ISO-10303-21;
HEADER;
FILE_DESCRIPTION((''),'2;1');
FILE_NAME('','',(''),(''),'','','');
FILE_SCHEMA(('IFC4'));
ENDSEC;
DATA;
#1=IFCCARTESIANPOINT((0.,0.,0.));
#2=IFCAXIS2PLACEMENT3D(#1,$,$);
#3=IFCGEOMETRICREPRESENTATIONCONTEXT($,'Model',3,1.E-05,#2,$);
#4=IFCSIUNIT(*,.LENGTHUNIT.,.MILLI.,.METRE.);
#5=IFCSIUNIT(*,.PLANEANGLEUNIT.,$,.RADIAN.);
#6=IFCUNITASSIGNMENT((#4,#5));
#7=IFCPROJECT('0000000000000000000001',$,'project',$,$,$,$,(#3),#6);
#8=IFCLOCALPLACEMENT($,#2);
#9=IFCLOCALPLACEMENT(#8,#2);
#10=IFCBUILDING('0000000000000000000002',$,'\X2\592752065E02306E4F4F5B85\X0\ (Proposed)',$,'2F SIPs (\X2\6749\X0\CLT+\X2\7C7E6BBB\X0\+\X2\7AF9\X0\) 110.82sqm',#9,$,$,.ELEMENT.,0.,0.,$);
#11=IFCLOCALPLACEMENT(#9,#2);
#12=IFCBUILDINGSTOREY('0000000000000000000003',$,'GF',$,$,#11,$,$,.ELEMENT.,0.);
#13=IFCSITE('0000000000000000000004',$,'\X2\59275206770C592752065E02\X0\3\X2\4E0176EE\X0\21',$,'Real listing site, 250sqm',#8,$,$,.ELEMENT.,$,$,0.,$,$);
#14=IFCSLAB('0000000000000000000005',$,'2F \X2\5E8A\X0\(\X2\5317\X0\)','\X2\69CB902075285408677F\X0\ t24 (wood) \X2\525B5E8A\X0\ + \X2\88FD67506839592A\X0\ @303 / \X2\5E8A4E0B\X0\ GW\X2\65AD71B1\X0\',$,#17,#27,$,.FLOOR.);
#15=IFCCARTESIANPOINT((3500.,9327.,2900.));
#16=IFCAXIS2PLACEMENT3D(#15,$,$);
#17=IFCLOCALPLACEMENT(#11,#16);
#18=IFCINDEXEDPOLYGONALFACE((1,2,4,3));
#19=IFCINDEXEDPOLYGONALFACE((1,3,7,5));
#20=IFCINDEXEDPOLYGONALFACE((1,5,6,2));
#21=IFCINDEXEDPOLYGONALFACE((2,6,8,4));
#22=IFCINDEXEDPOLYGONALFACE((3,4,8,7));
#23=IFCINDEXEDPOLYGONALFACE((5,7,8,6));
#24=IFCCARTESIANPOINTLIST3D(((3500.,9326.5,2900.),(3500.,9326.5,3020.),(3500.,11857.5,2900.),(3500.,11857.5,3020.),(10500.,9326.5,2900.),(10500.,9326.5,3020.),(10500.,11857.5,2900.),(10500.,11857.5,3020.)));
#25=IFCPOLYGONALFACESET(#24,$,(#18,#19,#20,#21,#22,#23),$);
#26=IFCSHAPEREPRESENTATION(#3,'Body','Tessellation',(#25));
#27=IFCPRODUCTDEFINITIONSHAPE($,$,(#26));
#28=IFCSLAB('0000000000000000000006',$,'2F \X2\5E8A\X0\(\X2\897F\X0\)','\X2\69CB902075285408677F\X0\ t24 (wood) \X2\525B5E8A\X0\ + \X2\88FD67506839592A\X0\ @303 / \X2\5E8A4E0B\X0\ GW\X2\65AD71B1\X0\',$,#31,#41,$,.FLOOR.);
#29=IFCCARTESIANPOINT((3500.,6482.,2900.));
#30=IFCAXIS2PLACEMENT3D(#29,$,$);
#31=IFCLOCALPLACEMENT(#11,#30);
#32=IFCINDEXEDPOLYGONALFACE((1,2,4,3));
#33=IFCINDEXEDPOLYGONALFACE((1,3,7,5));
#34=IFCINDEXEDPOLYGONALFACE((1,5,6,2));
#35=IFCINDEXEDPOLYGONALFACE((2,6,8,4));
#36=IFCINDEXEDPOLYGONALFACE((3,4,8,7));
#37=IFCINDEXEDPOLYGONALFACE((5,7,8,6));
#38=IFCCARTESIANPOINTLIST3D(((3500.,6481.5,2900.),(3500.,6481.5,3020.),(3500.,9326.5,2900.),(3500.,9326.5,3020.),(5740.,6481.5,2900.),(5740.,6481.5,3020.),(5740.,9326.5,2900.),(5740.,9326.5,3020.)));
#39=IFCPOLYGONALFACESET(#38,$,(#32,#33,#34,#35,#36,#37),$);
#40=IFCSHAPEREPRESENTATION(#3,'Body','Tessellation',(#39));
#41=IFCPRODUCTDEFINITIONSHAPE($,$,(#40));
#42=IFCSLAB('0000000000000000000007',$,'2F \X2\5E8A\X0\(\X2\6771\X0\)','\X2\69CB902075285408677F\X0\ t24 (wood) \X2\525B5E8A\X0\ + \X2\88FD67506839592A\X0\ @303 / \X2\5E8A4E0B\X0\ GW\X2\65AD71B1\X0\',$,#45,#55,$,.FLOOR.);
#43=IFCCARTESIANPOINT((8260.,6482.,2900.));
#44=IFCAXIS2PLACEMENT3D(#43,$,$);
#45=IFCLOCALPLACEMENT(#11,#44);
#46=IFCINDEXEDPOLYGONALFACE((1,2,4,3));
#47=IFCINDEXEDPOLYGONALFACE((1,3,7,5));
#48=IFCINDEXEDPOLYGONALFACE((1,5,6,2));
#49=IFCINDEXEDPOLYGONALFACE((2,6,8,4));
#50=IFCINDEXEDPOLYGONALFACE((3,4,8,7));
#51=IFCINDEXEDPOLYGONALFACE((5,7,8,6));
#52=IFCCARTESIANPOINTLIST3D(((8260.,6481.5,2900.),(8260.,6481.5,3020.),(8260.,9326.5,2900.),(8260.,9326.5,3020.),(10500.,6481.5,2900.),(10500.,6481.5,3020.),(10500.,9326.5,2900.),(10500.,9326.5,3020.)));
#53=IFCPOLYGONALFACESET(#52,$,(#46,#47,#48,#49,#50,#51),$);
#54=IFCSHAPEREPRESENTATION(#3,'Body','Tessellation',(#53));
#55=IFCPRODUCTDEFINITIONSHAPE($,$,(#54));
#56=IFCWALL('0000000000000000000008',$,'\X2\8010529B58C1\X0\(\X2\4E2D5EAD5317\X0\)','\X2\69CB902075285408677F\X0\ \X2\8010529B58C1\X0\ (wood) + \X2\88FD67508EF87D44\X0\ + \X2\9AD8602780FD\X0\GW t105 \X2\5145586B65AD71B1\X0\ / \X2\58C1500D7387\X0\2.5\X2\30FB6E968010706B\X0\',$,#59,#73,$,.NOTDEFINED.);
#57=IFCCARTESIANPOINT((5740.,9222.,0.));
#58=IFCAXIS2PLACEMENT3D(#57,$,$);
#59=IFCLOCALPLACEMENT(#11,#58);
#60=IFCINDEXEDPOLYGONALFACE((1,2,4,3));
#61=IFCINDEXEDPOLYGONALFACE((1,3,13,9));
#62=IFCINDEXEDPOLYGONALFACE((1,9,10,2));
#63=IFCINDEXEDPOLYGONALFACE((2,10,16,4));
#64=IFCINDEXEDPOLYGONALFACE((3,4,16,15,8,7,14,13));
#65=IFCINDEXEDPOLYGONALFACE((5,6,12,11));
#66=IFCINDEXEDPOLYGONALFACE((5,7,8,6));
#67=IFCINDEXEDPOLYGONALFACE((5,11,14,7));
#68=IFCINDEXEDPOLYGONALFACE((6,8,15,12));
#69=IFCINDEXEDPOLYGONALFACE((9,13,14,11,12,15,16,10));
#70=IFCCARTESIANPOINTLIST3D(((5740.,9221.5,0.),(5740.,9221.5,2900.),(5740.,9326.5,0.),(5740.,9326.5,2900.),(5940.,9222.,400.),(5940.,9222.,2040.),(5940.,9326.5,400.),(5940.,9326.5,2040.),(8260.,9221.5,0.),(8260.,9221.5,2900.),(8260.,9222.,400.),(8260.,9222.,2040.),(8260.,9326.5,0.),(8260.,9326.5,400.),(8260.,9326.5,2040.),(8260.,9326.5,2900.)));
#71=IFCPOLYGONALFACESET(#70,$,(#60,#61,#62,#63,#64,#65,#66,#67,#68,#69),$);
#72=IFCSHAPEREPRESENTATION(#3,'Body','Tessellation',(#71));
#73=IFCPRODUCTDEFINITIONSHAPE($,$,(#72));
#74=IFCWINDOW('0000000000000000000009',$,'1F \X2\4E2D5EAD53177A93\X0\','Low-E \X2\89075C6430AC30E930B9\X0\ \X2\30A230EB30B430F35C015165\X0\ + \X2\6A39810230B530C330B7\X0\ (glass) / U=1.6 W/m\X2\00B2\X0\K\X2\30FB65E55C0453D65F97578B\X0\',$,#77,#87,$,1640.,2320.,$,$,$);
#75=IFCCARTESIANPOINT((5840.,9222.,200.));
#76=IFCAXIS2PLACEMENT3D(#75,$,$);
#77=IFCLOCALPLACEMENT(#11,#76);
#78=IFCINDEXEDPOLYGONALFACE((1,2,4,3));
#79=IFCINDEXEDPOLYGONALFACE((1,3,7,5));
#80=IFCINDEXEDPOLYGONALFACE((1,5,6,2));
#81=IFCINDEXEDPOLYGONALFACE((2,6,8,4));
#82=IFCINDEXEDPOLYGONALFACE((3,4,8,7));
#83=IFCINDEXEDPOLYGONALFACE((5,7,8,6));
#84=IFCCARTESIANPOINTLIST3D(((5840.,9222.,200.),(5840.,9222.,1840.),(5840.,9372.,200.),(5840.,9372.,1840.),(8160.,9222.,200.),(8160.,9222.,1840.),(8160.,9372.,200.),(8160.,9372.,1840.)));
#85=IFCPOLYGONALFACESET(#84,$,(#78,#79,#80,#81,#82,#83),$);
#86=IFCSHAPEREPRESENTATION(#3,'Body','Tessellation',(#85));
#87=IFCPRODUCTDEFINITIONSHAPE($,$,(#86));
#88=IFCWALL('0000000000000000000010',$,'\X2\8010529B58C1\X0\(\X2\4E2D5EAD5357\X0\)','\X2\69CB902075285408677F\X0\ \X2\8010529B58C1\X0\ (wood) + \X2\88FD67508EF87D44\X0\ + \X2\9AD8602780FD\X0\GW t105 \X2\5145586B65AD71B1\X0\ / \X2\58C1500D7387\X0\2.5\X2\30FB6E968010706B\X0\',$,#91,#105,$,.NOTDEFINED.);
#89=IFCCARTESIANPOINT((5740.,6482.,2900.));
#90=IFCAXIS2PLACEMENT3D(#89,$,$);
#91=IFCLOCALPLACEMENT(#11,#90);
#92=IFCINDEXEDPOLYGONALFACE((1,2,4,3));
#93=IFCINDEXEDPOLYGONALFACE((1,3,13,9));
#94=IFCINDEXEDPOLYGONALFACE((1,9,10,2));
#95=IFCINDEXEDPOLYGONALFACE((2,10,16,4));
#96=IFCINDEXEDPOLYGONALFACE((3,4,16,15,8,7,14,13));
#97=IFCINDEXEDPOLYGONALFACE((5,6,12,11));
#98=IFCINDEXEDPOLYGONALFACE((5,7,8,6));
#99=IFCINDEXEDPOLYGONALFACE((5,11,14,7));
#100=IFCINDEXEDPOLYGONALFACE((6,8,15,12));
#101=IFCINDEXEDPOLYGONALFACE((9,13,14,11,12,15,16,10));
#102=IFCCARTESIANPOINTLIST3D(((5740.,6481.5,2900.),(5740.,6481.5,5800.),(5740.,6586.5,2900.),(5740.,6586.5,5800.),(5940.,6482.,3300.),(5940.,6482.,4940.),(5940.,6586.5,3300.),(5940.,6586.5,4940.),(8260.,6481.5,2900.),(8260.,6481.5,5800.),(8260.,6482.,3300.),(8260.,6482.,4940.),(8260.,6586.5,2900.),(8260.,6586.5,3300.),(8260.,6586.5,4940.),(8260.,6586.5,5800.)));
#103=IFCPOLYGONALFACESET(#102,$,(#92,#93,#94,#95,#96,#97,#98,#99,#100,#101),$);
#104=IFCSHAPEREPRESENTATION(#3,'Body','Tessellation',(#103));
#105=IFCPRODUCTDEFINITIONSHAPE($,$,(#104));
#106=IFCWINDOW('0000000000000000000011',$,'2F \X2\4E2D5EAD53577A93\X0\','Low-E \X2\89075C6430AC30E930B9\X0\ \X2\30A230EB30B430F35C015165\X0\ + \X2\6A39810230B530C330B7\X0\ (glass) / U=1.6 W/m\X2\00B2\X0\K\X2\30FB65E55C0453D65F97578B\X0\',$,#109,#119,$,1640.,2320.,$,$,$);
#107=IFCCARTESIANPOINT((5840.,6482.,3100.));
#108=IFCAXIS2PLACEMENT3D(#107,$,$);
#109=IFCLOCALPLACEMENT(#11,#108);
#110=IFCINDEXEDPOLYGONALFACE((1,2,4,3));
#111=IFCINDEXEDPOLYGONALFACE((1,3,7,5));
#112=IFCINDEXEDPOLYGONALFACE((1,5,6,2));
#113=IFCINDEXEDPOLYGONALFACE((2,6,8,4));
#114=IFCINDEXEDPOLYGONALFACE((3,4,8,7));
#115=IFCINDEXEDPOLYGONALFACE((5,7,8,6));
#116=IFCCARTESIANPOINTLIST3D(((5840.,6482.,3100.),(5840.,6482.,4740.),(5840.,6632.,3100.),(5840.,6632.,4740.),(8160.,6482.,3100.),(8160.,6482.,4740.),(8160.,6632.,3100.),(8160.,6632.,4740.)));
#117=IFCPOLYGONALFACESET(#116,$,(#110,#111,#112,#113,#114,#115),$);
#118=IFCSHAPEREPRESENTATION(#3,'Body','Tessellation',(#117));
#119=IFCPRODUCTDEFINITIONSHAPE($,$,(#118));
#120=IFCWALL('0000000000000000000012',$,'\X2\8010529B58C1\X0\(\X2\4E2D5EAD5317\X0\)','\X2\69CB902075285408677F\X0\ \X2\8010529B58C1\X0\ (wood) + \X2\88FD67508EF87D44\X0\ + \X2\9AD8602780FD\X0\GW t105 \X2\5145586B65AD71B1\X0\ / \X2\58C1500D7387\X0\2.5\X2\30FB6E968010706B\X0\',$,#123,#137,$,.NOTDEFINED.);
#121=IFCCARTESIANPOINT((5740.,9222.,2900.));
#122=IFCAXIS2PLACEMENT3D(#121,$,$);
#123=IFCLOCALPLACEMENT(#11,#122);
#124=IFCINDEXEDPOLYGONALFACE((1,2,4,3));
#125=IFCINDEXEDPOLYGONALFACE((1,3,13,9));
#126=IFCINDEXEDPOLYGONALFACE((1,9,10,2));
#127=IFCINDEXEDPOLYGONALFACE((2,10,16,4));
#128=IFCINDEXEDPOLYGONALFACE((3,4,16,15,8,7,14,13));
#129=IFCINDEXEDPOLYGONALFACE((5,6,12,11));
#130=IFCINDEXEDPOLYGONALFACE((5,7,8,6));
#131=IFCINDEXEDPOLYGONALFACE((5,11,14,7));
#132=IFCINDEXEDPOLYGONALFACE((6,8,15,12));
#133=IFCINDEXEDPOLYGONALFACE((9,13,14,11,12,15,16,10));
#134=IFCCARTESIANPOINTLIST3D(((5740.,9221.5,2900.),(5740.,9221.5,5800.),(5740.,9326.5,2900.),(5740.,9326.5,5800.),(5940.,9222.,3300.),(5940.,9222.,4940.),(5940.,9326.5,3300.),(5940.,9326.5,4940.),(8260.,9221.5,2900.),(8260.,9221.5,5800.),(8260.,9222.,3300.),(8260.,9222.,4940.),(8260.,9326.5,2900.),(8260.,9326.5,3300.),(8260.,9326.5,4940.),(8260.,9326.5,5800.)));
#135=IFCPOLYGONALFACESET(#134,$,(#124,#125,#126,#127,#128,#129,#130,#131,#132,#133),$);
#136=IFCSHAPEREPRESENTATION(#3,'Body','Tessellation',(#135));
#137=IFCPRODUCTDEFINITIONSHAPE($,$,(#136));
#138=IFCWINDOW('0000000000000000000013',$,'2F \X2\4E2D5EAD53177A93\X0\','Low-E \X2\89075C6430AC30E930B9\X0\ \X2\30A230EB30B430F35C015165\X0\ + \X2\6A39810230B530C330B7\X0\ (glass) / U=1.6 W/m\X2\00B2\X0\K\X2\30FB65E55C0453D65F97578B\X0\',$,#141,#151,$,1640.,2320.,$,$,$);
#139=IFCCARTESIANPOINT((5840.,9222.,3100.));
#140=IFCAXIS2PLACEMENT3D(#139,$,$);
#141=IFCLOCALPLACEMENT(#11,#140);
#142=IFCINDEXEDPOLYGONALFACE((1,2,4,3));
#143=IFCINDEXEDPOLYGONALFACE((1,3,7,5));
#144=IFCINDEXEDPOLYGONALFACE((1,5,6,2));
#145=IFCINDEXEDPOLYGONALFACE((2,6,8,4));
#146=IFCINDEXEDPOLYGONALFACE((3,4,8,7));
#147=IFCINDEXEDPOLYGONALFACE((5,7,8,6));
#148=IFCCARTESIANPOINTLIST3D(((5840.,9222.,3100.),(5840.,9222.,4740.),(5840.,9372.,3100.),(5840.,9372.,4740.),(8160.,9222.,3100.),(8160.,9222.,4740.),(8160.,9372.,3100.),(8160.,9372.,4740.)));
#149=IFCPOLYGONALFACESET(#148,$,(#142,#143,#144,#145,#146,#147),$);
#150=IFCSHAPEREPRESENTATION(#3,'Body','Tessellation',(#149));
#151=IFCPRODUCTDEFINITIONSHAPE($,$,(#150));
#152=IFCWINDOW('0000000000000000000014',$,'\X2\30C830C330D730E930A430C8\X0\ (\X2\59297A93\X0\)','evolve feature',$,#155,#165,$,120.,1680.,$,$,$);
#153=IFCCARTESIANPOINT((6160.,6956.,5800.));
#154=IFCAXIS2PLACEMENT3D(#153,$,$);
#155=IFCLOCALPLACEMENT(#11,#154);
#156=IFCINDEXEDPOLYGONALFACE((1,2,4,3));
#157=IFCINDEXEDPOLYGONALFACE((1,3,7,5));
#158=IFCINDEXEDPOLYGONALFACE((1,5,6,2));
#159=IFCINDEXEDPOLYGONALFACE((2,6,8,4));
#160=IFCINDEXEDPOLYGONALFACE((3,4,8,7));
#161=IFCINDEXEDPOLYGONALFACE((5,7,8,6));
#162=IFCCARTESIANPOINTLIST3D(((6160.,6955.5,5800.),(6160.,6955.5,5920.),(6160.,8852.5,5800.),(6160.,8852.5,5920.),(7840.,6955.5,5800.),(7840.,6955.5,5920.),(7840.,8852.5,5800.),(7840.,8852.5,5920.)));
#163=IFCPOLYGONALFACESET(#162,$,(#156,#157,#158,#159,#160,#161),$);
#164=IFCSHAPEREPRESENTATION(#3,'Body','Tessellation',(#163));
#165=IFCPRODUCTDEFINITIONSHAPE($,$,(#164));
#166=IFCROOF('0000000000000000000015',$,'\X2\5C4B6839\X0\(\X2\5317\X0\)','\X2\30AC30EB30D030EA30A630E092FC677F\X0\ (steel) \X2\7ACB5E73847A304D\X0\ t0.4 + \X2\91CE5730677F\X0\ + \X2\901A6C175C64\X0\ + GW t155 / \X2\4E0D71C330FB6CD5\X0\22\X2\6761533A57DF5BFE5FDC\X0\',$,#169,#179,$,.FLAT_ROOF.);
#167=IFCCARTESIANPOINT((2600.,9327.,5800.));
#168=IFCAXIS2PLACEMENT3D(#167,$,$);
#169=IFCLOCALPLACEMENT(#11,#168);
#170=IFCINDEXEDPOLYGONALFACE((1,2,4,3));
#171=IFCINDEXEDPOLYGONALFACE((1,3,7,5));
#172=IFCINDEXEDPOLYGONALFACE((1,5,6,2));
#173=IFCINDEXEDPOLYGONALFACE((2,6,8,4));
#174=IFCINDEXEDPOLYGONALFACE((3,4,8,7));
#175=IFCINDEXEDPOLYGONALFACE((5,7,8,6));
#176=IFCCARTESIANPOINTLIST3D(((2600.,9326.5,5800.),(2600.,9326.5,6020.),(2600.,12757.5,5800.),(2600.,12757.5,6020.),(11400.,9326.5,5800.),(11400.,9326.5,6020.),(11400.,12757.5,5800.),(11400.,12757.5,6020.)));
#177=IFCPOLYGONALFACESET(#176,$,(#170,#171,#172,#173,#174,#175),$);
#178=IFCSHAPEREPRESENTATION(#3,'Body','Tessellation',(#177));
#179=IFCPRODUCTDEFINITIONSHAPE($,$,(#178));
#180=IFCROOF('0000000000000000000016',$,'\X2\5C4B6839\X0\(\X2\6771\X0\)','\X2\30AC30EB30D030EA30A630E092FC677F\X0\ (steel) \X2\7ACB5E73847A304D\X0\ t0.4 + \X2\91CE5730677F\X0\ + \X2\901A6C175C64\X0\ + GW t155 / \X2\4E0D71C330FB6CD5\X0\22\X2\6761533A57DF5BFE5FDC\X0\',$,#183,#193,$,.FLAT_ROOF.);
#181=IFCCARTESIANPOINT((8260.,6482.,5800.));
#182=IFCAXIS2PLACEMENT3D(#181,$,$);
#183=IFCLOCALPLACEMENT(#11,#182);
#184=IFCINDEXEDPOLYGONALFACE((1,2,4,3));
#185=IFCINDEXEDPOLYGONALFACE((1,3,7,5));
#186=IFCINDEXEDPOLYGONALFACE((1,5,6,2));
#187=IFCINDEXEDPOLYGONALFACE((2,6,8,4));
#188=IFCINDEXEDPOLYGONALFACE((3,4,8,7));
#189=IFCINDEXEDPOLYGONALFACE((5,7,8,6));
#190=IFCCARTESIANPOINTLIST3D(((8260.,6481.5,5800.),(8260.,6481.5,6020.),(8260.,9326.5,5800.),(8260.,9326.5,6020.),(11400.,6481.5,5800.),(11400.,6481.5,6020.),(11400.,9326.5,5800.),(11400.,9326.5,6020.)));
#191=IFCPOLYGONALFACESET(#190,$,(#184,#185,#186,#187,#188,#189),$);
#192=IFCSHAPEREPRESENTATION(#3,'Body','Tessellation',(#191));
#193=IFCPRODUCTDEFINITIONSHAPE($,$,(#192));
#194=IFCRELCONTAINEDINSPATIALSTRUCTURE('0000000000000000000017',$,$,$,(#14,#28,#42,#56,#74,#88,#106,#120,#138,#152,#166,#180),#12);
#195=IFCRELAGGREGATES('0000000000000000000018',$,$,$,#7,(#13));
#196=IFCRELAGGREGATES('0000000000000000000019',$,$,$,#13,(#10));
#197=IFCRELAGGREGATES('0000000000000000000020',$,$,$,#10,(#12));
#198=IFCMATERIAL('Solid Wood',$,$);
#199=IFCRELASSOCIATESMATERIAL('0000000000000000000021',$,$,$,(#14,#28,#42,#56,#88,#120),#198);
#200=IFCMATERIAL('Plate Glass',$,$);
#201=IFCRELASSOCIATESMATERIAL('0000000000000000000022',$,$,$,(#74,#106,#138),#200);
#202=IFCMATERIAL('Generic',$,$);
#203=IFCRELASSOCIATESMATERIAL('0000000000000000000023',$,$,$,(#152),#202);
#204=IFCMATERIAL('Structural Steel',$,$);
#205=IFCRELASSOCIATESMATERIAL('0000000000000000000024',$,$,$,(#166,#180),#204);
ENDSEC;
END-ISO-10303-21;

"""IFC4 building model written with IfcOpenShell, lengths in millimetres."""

from ifc_helpers import new_model, si_unit, frame, frame_2d, origin, place, context, project, spatial, rectangle, extrude, material, element, fill, save


model = new_model("IFC4")

# Units and contexts
model_context = context("Model", 3, precision=1e-05, world=origin())
ifc_project = project(units=[si_unit("LENGTHUNIT", "METRE", prefix="MILLI"), si_unit("PLANEANGLEUNIT", "RADIAN")], contexts=[model_context])

# Site, building, storey
site_placement = place(None, origin())
site = spatial("IfcSite", under=ifc_project, at=site_placement, Name="大分県大分市3丁目21", ObjectType="Real listing site, 250sqm", CompositionType="ELEMENT", RefElevation=0.0)
building_placement = place(site_placement, origin())
building = spatial("IfcBuilding", under=site, at=building_placement, Name="大分市の住宅 (Proposed)", ObjectType="2F SIPs (杉CLT+籾殻+竹) 110.82sqm", CompositionType="ELEMENT", ElevationOfRefHeight=0.0, ElevationOfTerrain=0.0)
storey_placement = place(building_placement, origin())
storey = spatial("IfcBuildingStorey", under=building, at=storey_placement, Name="GF", CompositionType="ELEMENT", Elevation=0.0)

# Slabs
ifc_material_1 = material(Name="Solid Wood")
slab_1_placement = place(storey_placement, frame((3500.0, 9327.0, 2900.0)))
element("IfcSlab", 1, at=slab_1_placement, inside=storey, material=ifc_material_1, Name="2F 床(北)", Description="構造用合板 t24 (wood) 剛床 + 製材根太 @303 / 床下 GW断熱", PredefinedType="FLOOR", context=model_context, shape_type="SweptSolid", body=[
    extrude(rectangle(XDim=7000.0, YDim=2531.0, at=frame_2d((3500.0, 1265.0))), frame((3500.0, 9327.0, 2900.0)), (0.0, 0.0, 1.0), 120.0),
])
slab_2_placement = place(storey_placement, frame((3500.0, 6482.0, 2900.0)))
element("IfcSlab", 2, at=slab_2_placement, inside=storey, material=ifc_material_1, Name="2F 床(西)", Description="構造用合板 t24 (wood) 剛床 + 製材根太 @303 / 床下 GW断熱", PredefinedType="FLOOR", context=model_context, shape_type="SweptSolid", body=[
    extrude(rectangle(XDim=2240.0, YDim=2845.0, at=frame_2d((1120.0, 1422.0))), frame((3500.0, 6482.0, 2900.0)), (0.0, 0.0, 1.0), 120.0),
])
slab_3_placement = place(storey_placement, frame((8260.0, 6482.0, 2900.0)))
element("IfcSlab", 3, at=slab_3_placement, inside=storey, material=ifc_material_1, Name="2F 床(東)", Description="構造用合板 t24 (wood) 剛床 + 製材根太 @303 / 床下 GW断熱", PredefinedType="FLOOR", context=model_context, shape_type="SweptSolid", body=[
    extrude(rectangle(XDim=2240.0, YDim=2845.0, at=frame_2d((1120.0, 1422.0))), frame((8260.0, 6482.0, 2900.0)), (0.0, 0.0, 1.0), 120.0),
])

# Wall, opening, window
wall_1_placement = place(storey_placement, frame((5740.0, 9222.0, 0.0)))
wall_1 = element("IfcWall", 4, at=wall_1_placement, inside=storey, material=ifc_material_1, Name="耐力壁(中庭北)", Description="構造用合板 耐力壁 (wood) + 製材軸組 + 高性能GW t105 充填断熱 / 壁倍率2.5・準耐火", PredefinedType="NOTDEFINED", context=model_context, shape_type="SweptSolid", body=[
    extrude(rectangle(XDim=2520.0, YDim=105.0, at=frame_2d((1260.0, 52.0))), frame((5740.0, 9222.0, 0.0)), (0.0, 0.0, 1.0), 2900.0),
])
opening_1_placement = place(storey_placement, frame((5840.0, 9222.0, 200.0)))
opening_1 = element("IfcOpeningElement", 5, at=opening_1_placement, cuts=wall_1, PredefinedType="NOTDEFINED", context=model_context, shape_type="SweptSolid", body=[
    extrude(rectangle(XDim=2320.0, YDim=150.0, at=frame_2d((1160.0, 75.0))), frame((5840.0, 9222.0, 200.0)), (0.0, 0.0, 1.0), 1640.0),
])
ifc_material_2 = material(Name="Plate Glass")
window_1_placement = place(storey_placement, frame((5840.0, 9222.0, 200.0)))
window_1 = element("IfcWindow", 6, at=window_1_placement, inside=storey, material=ifc_material_2, Name="1F 中庭北窓", Description="Low-E 複層ガラス アルゴン封入 + 樹脂サッシ (glass) / U=1.6 W/m²K・日射取得型", OverallHeight=1640.0, OverallWidth=2320.0, context=model_context, shape_type="SweptSolid", body=[
    extrude(rectangle(XDim=2320.0, YDim=150.0, at=frame_2d((1160.0, 75.0))), frame((5840.0, 9222.0, 200.0)), (0.0, 0.0, 1.0), 1640.0),
])
fill(opening_1, window_1)

# Walls, openings, windows
wall_2_placement = place(storey_placement, frame((5740.0, 6482.0, 2900.0)))
wall_2 = element("IfcWall", 7, at=wall_2_placement, inside=storey, material=ifc_material_1, Name="耐力壁(中庭南)", Description="構造用合板 耐力壁 (wood) + 製材軸組 + 高性能GW t105 充填断熱 / 壁倍率2.5・準耐火", PredefinedType="NOTDEFINED", context=model_context, shape_type="SweptSolid", body=[
    extrude(rectangle(XDim=2520.0, YDim=105.0, at=frame_2d((1260.0, 52.0))), frame((5740.0, 6482.0, 2900.0)), (0.0, 0.0, 1.0), 2900.0),
])
opening_2_placement = place(storey_placement, frame((5840.0, 6482.0, 3100.0)))
opening_2 = element("IfcOpeningElement", 8, at=opening_2_placement, cuts=wall_2, PredefinedType="NOTDEFINED", context=model_context, shape_type="SweptSolid", body=[
    extrude(rectangle(XDim=2320.0, YDim=150.0, at=frame_2d((1160.0, 75.0))), frame((5840.0, 6482.0, 3100.0)), (0.0, 0.0, 1.0), 1640.0),
])
window_2_placement = place(storey_placement, frame((5840.0, 6482.0, 3100.0)))
window_2 = element("IfcWindow", 9, at=window_2_placement, inside=storey, material=ifc_material_2, Name="2F 中庭南窓", Description="Low-E 複層ガラス アルゴン封入 + 樹脂サッシ (glass) / U=1.6 W/m²K・日射取得型", OverallHeight=1640.0, OverallWidth=2320.0, context=model_context, shape_type="SweptSolid", body=[
    extrude(rectangle(XDim=2320.0, YDim=150.0, at=frame_2d((1160.0, 75.0))), frame((5840.0, 6482.0, 3100.0)), (0.0, 0.0, 1.0), 1640.0),
])
fill(opening_2, window_2)
wall_3_placement = place(storey_placement, frame((5740.0, 9222.0, 2900.0)))
wall_3 = element("IfcWall", 10, at=wall_3_placement, inside=storey, material=ifc_material_1, Name="耐力壁(中庭北)", Description="構造用合板 耐力壁 (wood) + 製材軸組 + 高性能GW t105 充填断熱 / 壁倍率2.5・準耐火", PredefinedType="NOTDEFINED", context=model_context, shape_type="SweptSolid", body=[
    extrude(rectangle(XDim=2520.0, YDim=105.0, at=frame_2d((1260.0, 52.0))), frame((5740.0, 9222.0, 2900.0)), (0.0, 0.0, 1.0), 2900.0),
])
opening_3_placement = place(storey_placement, frame((5840.0, 9222.0, 3100.0)))
opening_3 = element("IfcOpeningElement", 11, at=opening_3_placement, cuts=wall_3, PredefinedType="NOTDEFINED", context=model_context, shape_type="SweptSolid", body=[
    extrude(rectangle(XDim=2320.0, YDim=150.0, at=frame_2d((1160.0, 75.0))), frame((5840.0, 9222.0, 3100.0)), (0.0, 0.0, 1.0), 1640.0),
])
window_3_placement = place(storey_placement, frame((5840.0, 9222.0, 3100.0)))
window_3 = element("IfcWindow", 12, at=window_3_placement, inside=storey, material=ifc_material_2, Name="2F 中庭北窓", Description="Low-E 複層ガラス アルゴン封入 + 樹脂サッシ (glass) / U=1.6 W/m²K・日射取得型", OverallHeight=1640.0, OverallWidth=2320.0, context=model_context, shape_type="SweptSolid", body=[
    extrude(rectangle(XDim=2320.0, YDim=150.0, at=frame_2d((1160.0, 75.0))), frame((5840.0, 9222.0, 3100.0)), (0.0, 0.0, 1.0), 1640.0),
])
fill(opening_3, window_3)

# Window
ifc_material_3 = material(Name="Generic")
window_4_placement = place(storey_placement, frame((6160.0, 6956.0, 5800.0)))
element("IfcWindow", 13, at=window_4_placement, inside=storey, material=ifc_material_3, Name="トップライト (天窓)", Description="evolve feature", OverallHeight=120.0, OverallWidth=1680.0, context=model_context, shape_type="SweptSolid", body=[
    extrude(rectangle(XDim=1680.0, YDim=1897.0, at=frame_2d((840.0, 948.0))), frame((6160.0, 6956.0, 5800.0)), (0.0, 0.0, 1.0), 120.0),
])

# Roofs
ifc_material_4 = material(Name="Structural Steel")
roof_1_placement = place(storey_placement, frame((2600.0, 9327.0, 5800.0)))
element("IfcRoof", 14, at=roof_1_placement, inside=storey, material=ifc_material_4, Name="屋根(北)", Description="ガルバリウム鋼板 (steel) 立平葺き t0.4 + 野地板 + 通気層 + GW t155 / 不燃・法22条区域対応", PredefinedType="FLAT_ROOF", context=model_context, shape_type="SweptSolid", body=[
    extrude(rectangle(XDim=8800.0, YDim=3431.0, at=frame_2d((4400.0, 1715.0))), frame((2600.0, 9327.0, 5800.0)), (0.0, 0.0, 1.0), 220.0),
])
roof_2_placement = place(storey_placement, frame((8260.0, 6482.0, 5800.0)))
element("IfcRoof", 15, at=roof_2_placement, inside=storey, material=ifc_material_4, Name="屋根(東)", Description="ガルバリウム鋼板 (steel) 立平葺き t0.4 + 野地板 + 通気層 + GW t155 / 不燃・法22条区域対応", PredefinedType="FLAT_ROOF", context=model_context, shape_type="SweptSolid", body=[
    extrude(rectangle(XDim=3140.0, YDim=2845.0, at=frame_2d((1570.0, 1422.0))), frame((8260.0, 6482.0, 5800.0)), (0.0, 0.0, 1.0), 220.0),
])

save(model, "model.ifc")
